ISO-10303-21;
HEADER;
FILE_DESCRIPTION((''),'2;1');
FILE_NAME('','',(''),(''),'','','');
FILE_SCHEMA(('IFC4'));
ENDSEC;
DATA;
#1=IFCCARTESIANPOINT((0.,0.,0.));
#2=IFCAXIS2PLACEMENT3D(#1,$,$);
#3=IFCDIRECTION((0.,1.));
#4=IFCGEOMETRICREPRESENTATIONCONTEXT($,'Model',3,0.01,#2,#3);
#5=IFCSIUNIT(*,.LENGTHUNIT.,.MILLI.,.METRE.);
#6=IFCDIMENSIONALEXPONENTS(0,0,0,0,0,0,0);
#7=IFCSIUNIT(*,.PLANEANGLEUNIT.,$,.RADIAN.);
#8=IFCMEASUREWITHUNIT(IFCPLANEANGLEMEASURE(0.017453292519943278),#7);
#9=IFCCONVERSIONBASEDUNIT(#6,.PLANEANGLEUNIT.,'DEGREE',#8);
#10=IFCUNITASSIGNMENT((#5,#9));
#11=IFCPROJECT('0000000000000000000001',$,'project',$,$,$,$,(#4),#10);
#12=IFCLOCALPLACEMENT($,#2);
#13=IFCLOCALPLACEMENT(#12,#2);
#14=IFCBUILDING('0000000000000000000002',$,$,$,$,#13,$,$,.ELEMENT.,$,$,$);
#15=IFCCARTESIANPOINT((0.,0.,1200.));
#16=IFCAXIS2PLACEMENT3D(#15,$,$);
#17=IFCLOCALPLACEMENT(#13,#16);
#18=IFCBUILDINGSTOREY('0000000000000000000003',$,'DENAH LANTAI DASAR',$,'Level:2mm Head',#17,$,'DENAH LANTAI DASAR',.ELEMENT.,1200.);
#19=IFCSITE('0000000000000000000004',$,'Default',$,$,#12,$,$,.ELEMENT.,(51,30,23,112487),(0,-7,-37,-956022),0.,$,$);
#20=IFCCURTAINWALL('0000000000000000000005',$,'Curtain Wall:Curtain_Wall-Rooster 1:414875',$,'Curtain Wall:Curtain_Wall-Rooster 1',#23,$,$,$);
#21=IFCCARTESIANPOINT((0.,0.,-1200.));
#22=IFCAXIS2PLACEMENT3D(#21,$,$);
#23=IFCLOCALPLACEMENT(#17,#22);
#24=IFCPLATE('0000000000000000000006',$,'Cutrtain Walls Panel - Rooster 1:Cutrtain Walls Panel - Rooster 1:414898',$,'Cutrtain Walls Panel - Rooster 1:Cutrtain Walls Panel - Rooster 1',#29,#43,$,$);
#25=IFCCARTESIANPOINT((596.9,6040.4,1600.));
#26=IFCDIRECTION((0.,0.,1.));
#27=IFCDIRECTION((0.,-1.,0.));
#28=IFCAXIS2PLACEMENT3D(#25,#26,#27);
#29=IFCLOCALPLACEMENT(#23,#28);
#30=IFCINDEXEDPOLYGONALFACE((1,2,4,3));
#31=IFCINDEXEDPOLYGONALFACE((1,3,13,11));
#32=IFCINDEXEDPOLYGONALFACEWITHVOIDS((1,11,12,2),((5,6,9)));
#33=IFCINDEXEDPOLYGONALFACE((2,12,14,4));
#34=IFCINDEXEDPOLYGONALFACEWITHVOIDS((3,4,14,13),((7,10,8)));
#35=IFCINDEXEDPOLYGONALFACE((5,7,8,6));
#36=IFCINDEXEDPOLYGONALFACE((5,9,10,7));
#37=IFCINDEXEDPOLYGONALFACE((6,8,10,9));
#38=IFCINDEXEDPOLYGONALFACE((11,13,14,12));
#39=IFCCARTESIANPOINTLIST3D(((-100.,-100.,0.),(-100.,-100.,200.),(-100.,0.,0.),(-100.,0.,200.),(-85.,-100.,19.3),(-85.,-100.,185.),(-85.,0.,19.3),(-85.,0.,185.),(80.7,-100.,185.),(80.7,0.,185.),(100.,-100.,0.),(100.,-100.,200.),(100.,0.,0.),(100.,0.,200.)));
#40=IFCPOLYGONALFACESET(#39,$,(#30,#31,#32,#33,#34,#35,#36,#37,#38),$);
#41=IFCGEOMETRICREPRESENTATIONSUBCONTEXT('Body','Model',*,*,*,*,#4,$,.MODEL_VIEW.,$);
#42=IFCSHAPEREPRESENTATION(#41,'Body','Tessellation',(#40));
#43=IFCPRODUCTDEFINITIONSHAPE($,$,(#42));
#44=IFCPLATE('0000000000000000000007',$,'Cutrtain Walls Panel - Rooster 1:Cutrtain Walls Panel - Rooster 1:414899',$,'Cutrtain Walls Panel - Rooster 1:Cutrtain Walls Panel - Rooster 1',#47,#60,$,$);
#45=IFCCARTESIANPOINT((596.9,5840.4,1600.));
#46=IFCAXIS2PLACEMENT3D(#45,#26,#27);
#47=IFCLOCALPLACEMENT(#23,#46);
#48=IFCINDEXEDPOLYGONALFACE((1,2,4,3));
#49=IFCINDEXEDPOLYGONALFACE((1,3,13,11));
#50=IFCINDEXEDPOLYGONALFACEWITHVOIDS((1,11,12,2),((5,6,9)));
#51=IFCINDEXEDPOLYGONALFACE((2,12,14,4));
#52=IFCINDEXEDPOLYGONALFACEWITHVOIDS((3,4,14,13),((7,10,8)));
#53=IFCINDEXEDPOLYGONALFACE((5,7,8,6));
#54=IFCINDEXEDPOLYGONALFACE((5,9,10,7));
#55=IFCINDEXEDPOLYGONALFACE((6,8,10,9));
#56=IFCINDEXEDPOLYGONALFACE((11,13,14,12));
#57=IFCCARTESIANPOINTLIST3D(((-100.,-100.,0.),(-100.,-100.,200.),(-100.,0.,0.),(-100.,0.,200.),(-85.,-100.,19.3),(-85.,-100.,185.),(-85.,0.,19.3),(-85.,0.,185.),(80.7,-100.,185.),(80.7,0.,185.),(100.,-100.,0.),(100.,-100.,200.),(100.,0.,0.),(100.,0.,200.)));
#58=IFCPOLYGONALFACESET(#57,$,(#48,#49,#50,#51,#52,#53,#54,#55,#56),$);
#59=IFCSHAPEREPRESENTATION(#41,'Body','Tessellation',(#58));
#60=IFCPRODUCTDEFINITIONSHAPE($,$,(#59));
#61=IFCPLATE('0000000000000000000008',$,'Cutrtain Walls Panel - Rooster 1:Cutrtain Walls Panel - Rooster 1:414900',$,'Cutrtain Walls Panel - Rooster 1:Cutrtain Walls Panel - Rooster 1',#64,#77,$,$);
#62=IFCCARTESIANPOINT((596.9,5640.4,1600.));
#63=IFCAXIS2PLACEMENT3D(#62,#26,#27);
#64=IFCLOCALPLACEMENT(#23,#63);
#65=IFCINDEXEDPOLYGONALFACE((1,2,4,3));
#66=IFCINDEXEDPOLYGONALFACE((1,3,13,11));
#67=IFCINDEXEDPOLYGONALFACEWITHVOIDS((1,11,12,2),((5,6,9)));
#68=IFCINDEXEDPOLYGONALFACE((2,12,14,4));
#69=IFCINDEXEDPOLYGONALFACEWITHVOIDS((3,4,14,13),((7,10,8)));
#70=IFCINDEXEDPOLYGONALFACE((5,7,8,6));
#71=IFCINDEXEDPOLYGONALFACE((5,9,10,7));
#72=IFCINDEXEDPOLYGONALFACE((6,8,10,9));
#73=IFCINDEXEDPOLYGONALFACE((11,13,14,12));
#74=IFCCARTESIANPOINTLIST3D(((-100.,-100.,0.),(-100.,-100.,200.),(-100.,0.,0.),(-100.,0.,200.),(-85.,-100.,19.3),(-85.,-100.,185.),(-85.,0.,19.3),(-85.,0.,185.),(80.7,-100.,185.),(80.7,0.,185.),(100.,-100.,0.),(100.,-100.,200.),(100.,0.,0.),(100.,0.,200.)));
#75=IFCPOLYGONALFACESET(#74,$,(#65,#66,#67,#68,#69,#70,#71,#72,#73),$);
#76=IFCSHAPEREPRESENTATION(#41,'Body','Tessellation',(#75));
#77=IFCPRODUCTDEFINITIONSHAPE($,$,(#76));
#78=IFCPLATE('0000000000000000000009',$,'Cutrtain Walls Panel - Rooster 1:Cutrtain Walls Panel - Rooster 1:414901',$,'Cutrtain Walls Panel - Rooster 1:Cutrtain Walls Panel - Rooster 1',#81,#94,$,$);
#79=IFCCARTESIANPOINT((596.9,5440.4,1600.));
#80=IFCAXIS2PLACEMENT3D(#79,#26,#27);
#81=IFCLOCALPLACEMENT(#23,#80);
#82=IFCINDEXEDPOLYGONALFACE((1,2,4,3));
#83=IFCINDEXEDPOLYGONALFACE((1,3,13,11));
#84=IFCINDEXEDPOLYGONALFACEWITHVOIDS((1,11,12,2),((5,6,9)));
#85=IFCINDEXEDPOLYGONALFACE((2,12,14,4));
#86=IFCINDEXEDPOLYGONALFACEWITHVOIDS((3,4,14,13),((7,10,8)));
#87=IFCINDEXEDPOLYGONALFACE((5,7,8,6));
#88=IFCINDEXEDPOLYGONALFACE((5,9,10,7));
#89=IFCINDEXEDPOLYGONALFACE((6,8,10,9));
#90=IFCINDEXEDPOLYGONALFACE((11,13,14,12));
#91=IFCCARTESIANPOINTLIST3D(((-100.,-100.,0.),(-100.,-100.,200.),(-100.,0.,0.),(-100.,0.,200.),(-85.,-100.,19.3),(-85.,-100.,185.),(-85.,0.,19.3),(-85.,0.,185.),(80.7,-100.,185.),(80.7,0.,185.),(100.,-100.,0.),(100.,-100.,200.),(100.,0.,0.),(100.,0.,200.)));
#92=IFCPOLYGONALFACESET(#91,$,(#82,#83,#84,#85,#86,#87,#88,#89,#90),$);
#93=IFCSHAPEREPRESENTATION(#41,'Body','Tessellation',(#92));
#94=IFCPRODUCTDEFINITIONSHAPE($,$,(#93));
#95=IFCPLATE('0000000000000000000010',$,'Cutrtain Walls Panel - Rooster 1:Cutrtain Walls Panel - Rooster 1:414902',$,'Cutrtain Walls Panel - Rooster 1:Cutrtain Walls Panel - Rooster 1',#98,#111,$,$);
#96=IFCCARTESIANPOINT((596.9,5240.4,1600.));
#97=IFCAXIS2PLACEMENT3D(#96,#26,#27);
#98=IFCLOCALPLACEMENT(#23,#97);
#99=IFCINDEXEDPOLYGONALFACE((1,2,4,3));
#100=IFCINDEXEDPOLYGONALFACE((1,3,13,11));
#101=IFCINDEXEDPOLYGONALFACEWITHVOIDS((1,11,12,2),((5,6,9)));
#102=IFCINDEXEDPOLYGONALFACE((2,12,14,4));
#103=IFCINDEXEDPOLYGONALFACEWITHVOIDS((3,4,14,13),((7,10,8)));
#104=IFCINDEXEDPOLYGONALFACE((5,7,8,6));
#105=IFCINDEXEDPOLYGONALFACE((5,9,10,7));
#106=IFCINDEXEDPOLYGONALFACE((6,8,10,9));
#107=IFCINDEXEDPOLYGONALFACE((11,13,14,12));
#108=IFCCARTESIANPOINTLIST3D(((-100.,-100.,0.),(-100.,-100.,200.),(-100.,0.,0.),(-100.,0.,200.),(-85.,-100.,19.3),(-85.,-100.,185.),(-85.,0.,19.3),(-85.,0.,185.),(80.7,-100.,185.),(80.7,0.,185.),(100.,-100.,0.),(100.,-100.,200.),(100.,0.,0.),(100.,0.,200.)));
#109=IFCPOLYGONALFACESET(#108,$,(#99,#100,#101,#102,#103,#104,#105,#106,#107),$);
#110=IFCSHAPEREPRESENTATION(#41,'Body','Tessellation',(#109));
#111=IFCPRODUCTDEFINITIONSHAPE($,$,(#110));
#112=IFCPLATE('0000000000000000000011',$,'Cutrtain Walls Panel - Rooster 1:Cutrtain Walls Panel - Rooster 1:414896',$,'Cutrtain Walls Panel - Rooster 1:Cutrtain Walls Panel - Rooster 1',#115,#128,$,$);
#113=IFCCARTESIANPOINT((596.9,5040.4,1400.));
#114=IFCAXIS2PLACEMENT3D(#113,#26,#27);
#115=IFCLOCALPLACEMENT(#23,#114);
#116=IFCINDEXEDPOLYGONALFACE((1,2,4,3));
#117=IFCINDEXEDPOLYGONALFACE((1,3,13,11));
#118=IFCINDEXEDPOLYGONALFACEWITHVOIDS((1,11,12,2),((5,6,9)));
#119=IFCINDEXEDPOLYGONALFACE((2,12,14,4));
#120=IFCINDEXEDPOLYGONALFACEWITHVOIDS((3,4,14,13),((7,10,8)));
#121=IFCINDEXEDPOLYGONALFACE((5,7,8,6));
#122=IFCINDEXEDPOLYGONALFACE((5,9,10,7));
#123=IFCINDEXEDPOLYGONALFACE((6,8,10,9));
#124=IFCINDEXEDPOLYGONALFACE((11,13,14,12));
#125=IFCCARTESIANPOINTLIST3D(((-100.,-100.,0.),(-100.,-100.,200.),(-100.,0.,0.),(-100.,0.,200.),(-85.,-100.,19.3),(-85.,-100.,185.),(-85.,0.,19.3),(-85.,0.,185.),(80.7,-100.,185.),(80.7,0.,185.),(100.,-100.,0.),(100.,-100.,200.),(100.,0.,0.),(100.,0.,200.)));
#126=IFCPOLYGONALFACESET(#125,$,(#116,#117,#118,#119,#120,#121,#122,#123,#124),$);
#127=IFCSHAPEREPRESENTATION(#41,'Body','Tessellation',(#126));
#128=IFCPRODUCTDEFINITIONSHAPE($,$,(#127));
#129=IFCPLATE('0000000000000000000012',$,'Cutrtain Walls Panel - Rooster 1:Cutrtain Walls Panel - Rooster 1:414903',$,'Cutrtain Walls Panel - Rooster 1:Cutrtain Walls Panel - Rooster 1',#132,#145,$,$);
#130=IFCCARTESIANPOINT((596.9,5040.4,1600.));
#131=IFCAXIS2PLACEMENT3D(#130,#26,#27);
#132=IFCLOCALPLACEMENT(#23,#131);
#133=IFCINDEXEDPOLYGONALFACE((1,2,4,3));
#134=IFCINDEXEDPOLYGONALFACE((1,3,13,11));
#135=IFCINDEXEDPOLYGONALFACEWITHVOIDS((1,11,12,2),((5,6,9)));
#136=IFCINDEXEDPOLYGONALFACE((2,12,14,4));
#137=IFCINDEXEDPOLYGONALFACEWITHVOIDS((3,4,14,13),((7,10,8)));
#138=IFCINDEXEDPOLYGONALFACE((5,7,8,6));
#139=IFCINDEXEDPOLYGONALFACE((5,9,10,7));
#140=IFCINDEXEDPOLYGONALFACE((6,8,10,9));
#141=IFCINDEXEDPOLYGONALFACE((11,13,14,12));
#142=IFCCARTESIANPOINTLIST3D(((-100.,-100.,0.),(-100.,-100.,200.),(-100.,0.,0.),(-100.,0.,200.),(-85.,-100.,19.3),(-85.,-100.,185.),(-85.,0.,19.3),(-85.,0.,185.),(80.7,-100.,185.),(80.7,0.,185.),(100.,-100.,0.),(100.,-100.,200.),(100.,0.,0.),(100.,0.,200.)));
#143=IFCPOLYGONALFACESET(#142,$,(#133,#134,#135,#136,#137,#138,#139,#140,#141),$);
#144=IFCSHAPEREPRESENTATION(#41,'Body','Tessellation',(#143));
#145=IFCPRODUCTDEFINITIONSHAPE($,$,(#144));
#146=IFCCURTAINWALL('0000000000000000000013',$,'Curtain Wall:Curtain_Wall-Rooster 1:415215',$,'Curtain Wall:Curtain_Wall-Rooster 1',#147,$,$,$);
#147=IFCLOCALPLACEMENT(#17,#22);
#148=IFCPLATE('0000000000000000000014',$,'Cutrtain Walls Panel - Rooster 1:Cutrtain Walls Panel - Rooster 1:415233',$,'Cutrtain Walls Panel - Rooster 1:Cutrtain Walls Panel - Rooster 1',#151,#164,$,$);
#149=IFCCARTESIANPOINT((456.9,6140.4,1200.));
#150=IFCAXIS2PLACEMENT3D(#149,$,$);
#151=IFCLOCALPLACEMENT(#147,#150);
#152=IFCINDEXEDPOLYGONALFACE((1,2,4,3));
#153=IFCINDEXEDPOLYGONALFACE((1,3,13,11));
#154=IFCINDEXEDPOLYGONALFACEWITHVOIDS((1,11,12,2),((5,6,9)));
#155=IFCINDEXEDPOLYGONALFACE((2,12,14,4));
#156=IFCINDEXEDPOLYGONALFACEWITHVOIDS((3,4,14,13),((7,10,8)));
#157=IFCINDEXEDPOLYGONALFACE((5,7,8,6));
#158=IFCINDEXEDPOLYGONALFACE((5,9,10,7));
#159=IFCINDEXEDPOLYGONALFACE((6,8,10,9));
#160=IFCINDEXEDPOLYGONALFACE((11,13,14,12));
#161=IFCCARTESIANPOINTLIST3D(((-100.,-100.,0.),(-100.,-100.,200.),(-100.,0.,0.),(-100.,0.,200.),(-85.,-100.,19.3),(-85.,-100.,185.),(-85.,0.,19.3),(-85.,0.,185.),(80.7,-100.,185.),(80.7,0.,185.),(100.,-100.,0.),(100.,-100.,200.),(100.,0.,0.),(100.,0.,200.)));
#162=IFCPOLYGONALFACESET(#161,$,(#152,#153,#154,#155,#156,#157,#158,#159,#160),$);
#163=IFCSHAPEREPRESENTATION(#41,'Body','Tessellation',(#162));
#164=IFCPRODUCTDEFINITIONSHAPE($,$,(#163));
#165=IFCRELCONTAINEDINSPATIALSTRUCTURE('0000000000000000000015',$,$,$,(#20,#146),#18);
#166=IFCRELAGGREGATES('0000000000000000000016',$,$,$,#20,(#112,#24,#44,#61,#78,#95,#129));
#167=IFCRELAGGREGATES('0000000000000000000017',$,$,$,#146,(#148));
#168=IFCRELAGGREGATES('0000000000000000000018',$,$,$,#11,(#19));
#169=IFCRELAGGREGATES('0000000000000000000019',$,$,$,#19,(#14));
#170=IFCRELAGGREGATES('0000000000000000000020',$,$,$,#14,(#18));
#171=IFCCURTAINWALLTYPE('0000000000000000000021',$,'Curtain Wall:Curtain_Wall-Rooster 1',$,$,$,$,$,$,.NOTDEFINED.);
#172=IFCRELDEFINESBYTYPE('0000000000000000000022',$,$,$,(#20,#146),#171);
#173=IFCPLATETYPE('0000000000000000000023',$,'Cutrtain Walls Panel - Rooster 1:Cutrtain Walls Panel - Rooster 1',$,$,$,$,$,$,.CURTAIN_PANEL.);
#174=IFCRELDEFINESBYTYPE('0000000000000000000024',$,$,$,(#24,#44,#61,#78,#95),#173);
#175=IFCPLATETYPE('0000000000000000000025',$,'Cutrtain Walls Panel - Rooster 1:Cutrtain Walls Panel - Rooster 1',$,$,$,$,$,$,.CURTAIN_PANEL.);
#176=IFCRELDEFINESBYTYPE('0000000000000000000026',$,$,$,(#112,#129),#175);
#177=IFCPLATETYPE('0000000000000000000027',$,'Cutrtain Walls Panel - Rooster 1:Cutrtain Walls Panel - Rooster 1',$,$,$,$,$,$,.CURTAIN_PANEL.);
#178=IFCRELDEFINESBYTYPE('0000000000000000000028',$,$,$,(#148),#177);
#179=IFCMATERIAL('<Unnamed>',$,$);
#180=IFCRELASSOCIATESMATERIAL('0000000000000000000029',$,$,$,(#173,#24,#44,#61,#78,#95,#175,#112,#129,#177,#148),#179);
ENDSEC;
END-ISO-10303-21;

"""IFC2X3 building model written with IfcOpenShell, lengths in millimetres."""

from ifc_helpers import new_model, entity, si_unit, converted_unit, direction, frame, origin, place, context, subcontext, project, spatial, polyline, outline, extrude, source, transform, mapped, material, type_object, type_shapes, element, aggregate, save


model = new_model("IFC2X3")

# Units and contexts
model_context = context("Model", 3, precision=0.01, world=origin(), true_north=direction((0.0, 1.0)))
body_context = subcontext(model_context, "Body", "Model", "MODEL_VIEW")
ifc_project = project(units=[si_unit("LENGTHUNIT", "METRE", prefix="MILLI"), converted_unit("PLANEANGLEUNIT", "DEGREE", entity("IfcPlaneAngleMeasure", 0.017453292519943278), si_unit("PLANEANGLEUNIT", "RADIAN"), dimensions=[0, 0, 0, 0, 0, 0, 0])], contexts=[model_context])

# Site, building, storey
site_placement = place(None, origin())
site = spatial("IfcSite", under=ifc_project, at=site_placement, Name="Default", CompositionType="ELEMENT", RefLatitude=(51, 30, 23, 112487), RefLongitude=(0, -7, -37, -956022), RefElevation=0.0)
building_placement = place(site_placement, origin())
building = spatial("IfcBuilding", under=site, at=building_placement, CompositionType="ELEMENT")
storey_placement = place(building_placement, frame((0.0, 0.0, 1200.0)))
storey = spatial("IfcBuildingStorey", under=building, at=storey_placement, Name="DENAH LANTAI DASAR", ObjectType="Level:2mm Head", LongName="DENAH LANTAI DASAR", CompositionType="ELEMENT", Elevation=1200.0)

# Curtain wall, plates
curtain_wall_type = type_object("IfcCurtainWallType", Name="Curtain Wall:Curtain_Wall-Rooster 1", PredefinedType="NOTDEFINED")
curtain_wall_1_placement = place(storey_placement, frame((0.0, 0.0, -1200.0)))
curtain_wall_1 = element("IfcCurtainWall", 1, at=curtain_wall_1_placement, inside=storey, type_object=curtain_wall_type, Name="Curtain Wall:Curtain_Wall-Rooster 1:414875", ObjectType="Curtain Wall:Curtain_Wall-Rooster 1")
ifc_material_1 = material(Name="<Unnamed>")
plate_type_1 = type_object("IfcPlateType", Name="Cutrtain Walls Panel - Rooster 1:Cutrtain Walls Panel - Rooster 1", PredefinedType="CURTAIN_PANEL", material=ifc_material_1)
shared_shape_1 = source(origin(), body_context, "Body", "SweptSolid", [
    extrude(outline(polyline([(-100.0, -100.0), (100.0, -100.0), (100.0, 100.0), (-100.0, 100.0), (-100.0, -100.0)]), holes=[polyline([(80.7, 85.0), (-85.0, -80.7), (-85.0, 85.0), (80.7, 85.0)])]), frame((0.0, -100.0, 100.0), z_axis=(0.0, 1.0, 0.0), x_axis=(0.0, 0.0, -1.0)), (0.0, 0.0, 1.0), 100.0),
])
type_shapes(plate_type_1, [shared_shape_1])
plate_1_placement = place(curtain_wall_1_placement, frame((596.9, 6040.4, 1600.0), z_axis=(0.0, 0.0, 1.0), x_axis=(0.0, -1.0, 0.0)))
plate_1 = element("IfcPlate", 2, at=plate_1_placement, type_object=plate_type_1, material=ifc_material_1, Name="Cutrtain Walls Panel - Rooster 1:Cutrtain Walls Panel - Rooster 1:414898", ObjectType="Cutrtain Walls Panel - Rooster 1:Cutrtain Walls Panel - Rooster 1", context=body_context, shape_type="MappedRepresentation", body=[
    mapped(shared_shape_1, transform((0.0, 0.0, 0.0), scale=1.0)),
])
plate_2_placement = place(curtain_wall_1_placement, frame((596.9, 5840.4, 1600.0), z_axis=(0.0, 0.0, 1.0), x_axis=(0.0, -1.0, 0.0)))
plate_2 = element("IfcPlate", 3, at=plate_2_placement, type_object=plate_type_1, material=ifc_material_1, Name="Cutrtain Walls Panel - Rooster 1:Cutrtain Walls Panel - Rooster 1:414899", ObjectType="Cutrtain Walls Panel - Rooster 1:Cutrtain Walls Panel - Rooster 1", context=body_context, shape_type="MappedRepresentation", body=[
    mapped(shared_shape_1, transform((0.0, 0.0, 0.0), scale=1.0)),
])
plate_3_placement = place(curtain_wall_1_placement, frame((596.9, 5640.4, 1600.0), z_axis=(0.0, 0.0, 1.0), x_axis=(0.0, -1.0, 0.0)))
plate_3 = element("IfcPlate", 4, at=plate_3_placement, type_object=plate_type_1, material=ifc_material_1, Name="Cutrtain Walls Panel - Rooster 1:Cutrtain Walls Panel - Rooster 1:414900", ObjectType="Cutrtain Walls Panel - Rooster 1:Cutrtain Walls Panel - Rooster 1", context=body_context, shape_type="MappedRepresentation", body=[
    mapped(shared_shape_1, transform((0.0, 0.0, 0.0), scale=1.0)),
])
plate_4_placement = place(curtain_wall_1_placement, frame((596.9, 5440.4, 1600.0), z_axis=(0.0, 0.0, 1.0), x_axis=(0.0, -1.0, 0.0)))
plate_4 = element("IfcPlate", 5, at=plate_4_placement, type_object=plate_type_1, material=ifc_material_1, Name="Cutrtain Walls Panel - Rooster 1:Cutrtain Walls Panel - Rooster 1:414901", ObjectType="Cutrtain Walls Panel - Rooster 1:Cutrtain Walls Panel - Rooster 1", context=body_context, shape_type="MappedRepresentation", body=[
    mapped(shared_shape_1, transform((0.0, 0.0, 0.0), scale=1.0)),
])
plate_5_placement = place(curtain_wall_1_placement, frame((596.9, 5240.4, 1600.0), z_axis=(0.0, 0.0, 1.0), x_axis=(0.0, -1.0, 0.0)))
plate_5 = element("IfcPlate", 6, at=plate_5_placement, type_object=plate_type_1, material=ifc_material_1, Name="Cutrtain Walls Panel - Rooster 1:Cutrtain Walls Panel - Rooster 1:414902", ObjectType="Cutrtain Walls Panel - Rooster 1:Cutrtain Walls Panel - Rooster 1", context=body_context, shape_type="MappedRepresentation", body=[
    mapped(shared_shape_1, transform((0.0, 0.0, 0.0), scale=1.0)),
])
plate_type_2 = type_object("IfcPlateType", Name="Cutrtain Walls Panel - Rooster 1:Cutrtain Walls Panel - Rooster 1", PredefinedType="CURTAIN_PANEL", material=ifc_material_1)
shared_shape_2 = source(origin(), body_context, "Body", "SweptSolid", [
    extrude(outline(polyline([(-100.0, -100.0), (100.0, -100.0), (100.0, 100.0), (-100.0, 100.0), (-100.0, -100.0)]), holes=[polyline([(80.7, 85.0), (-85.0, -80.7), (-85.0, 85.0), (80.7, 85.0)])]), frame((0.0, -100.0, 100.0), z_axis=(0.0, 1.0, 0.0), x_axis=(0.0, 0.0, -1.0)), (0.0, 0.0, 1.0), 100.0),
])
type_shapes(plate_type_2, [shared_shape_2])
plate_6_placement = place(curtain_wall_1_placement, frame((596.9, 5040.4, 1400.0), z_axis=(0.0, 0.0, 1.0), x_axis=(0.0, -1.0, 0.0)))
plate_6 = element("IfcPlate", 7, at=plate_6_placement, type_object=plate_type_2, material=ifc_material_1, Name="Cutrtain Walls Panel - Rooster 1:Cutrtain Walls Panel - Rooster 1:414896", ObjectType="Cutrtain Walls Panel - Rooster 1:Cutrtain Walls Panel - Rooster 1", context=body_context, shape_type="MappedRepresentation", body=[
    mapped(shared_shape_2, transform((0.0, 0.0, 0.0), scale=1.0)),
])
plate_7_placement = place(curtain_wall_1_placement, frame((596.9, 5040.4, 1600.0), z_axis=(0.0, 0.0, 1.0), x_axis=(0.0, -1.0, 0.0)))
plate_7 = element("IfcPlate", 8, at=plate_7_placement, type_object=plate_type_2, material=ifc_material_1, Name="Cutrtain Walls Panel - Rooster 1:Cutrtain Walls Panel - Rooster 1:414903", ObjectType="Cutrtain Walls Panel - Rooster 1:Cutrtain Walls Panel - Rooster 1", context=body_context, shape_type="MappedRepresentation", body=[
    mapped(shared_shape_2, transform((0.0, 0.0, 0.0), scale=1.0)),
])
aggregate(curtain_wall_1, [plate_6, plate_1, plate_2, plate_3, plate_4, plate_5, plate_7])

# Curtain wall, plate
curtain_wall_2_placement = place(storey_placement, frame((0.0, 0.0, -1200.0)))
curtain_wall_2 = element("IfcCurtainWall", 9, at=curtain_wall_2_placement, inside=storey, type_object=curtain_wall_type, Name="Curtain Wall:Curtain_Wall-Rooster 1:415215", ObjectType="Curtain Wall:Curtain_Wall-Rooster 1")
plate_type_3 = type_object("IfcPlateType", Name="Cutrtain Walls Panel - Rooster 1:Cutrtain Walls Panel - Rooster 1", PredefinedType="CURTAIN_PANEL", material=ifc_material_1)
shared_shape_3 = source(origin(), body_context, "Body", "SweptSolid", [
    extrude(outline(polyline([(-100.0, -100.0), (100.0, -100.0), (100.0, 100.0), (-100.0, 100.0), (-100.0, -100.0)]), holes=[polyline([(80.7, 85.0), (-85.0, -80.7), (-85.0, 85.0), (80.7, 85.0)])]), frame((0.0, -100.0, 100.0), z_axis=(0.0, 1.0, 0.0), x_axis=(0.0, 0.0, -1.0)), (0.0, 0.0, 1.0), 100.0),
])
type_shapes(plate_type_3, [shared_shape_3])
plate_8_placement = place(curtain_wall_2_placement, frame((456.9, 6140.4, 1200.0)))
plate_8 = element("IfcPlate", 10, at=plate_8_placement, type_object=plate_type_3, material=ifc_material_1, Name="Cutrtain Walls Panel - Rooster 1:Cutrtain Walls Panel - Rooster 1:415233", ObjectType="Cutrtain Walls Panel - Rooster 1:Cutrtain Walls Panel - Rooster 1", context=body_context, shape_type="MappedRepresentation", body=[
    mapped(shared_shape_3, transform((0.0, 0.0, 0.0), scale=1.0)),
])
aggregate(curtain_wall_2, [plate_8])

save(model, "model.ifc")
